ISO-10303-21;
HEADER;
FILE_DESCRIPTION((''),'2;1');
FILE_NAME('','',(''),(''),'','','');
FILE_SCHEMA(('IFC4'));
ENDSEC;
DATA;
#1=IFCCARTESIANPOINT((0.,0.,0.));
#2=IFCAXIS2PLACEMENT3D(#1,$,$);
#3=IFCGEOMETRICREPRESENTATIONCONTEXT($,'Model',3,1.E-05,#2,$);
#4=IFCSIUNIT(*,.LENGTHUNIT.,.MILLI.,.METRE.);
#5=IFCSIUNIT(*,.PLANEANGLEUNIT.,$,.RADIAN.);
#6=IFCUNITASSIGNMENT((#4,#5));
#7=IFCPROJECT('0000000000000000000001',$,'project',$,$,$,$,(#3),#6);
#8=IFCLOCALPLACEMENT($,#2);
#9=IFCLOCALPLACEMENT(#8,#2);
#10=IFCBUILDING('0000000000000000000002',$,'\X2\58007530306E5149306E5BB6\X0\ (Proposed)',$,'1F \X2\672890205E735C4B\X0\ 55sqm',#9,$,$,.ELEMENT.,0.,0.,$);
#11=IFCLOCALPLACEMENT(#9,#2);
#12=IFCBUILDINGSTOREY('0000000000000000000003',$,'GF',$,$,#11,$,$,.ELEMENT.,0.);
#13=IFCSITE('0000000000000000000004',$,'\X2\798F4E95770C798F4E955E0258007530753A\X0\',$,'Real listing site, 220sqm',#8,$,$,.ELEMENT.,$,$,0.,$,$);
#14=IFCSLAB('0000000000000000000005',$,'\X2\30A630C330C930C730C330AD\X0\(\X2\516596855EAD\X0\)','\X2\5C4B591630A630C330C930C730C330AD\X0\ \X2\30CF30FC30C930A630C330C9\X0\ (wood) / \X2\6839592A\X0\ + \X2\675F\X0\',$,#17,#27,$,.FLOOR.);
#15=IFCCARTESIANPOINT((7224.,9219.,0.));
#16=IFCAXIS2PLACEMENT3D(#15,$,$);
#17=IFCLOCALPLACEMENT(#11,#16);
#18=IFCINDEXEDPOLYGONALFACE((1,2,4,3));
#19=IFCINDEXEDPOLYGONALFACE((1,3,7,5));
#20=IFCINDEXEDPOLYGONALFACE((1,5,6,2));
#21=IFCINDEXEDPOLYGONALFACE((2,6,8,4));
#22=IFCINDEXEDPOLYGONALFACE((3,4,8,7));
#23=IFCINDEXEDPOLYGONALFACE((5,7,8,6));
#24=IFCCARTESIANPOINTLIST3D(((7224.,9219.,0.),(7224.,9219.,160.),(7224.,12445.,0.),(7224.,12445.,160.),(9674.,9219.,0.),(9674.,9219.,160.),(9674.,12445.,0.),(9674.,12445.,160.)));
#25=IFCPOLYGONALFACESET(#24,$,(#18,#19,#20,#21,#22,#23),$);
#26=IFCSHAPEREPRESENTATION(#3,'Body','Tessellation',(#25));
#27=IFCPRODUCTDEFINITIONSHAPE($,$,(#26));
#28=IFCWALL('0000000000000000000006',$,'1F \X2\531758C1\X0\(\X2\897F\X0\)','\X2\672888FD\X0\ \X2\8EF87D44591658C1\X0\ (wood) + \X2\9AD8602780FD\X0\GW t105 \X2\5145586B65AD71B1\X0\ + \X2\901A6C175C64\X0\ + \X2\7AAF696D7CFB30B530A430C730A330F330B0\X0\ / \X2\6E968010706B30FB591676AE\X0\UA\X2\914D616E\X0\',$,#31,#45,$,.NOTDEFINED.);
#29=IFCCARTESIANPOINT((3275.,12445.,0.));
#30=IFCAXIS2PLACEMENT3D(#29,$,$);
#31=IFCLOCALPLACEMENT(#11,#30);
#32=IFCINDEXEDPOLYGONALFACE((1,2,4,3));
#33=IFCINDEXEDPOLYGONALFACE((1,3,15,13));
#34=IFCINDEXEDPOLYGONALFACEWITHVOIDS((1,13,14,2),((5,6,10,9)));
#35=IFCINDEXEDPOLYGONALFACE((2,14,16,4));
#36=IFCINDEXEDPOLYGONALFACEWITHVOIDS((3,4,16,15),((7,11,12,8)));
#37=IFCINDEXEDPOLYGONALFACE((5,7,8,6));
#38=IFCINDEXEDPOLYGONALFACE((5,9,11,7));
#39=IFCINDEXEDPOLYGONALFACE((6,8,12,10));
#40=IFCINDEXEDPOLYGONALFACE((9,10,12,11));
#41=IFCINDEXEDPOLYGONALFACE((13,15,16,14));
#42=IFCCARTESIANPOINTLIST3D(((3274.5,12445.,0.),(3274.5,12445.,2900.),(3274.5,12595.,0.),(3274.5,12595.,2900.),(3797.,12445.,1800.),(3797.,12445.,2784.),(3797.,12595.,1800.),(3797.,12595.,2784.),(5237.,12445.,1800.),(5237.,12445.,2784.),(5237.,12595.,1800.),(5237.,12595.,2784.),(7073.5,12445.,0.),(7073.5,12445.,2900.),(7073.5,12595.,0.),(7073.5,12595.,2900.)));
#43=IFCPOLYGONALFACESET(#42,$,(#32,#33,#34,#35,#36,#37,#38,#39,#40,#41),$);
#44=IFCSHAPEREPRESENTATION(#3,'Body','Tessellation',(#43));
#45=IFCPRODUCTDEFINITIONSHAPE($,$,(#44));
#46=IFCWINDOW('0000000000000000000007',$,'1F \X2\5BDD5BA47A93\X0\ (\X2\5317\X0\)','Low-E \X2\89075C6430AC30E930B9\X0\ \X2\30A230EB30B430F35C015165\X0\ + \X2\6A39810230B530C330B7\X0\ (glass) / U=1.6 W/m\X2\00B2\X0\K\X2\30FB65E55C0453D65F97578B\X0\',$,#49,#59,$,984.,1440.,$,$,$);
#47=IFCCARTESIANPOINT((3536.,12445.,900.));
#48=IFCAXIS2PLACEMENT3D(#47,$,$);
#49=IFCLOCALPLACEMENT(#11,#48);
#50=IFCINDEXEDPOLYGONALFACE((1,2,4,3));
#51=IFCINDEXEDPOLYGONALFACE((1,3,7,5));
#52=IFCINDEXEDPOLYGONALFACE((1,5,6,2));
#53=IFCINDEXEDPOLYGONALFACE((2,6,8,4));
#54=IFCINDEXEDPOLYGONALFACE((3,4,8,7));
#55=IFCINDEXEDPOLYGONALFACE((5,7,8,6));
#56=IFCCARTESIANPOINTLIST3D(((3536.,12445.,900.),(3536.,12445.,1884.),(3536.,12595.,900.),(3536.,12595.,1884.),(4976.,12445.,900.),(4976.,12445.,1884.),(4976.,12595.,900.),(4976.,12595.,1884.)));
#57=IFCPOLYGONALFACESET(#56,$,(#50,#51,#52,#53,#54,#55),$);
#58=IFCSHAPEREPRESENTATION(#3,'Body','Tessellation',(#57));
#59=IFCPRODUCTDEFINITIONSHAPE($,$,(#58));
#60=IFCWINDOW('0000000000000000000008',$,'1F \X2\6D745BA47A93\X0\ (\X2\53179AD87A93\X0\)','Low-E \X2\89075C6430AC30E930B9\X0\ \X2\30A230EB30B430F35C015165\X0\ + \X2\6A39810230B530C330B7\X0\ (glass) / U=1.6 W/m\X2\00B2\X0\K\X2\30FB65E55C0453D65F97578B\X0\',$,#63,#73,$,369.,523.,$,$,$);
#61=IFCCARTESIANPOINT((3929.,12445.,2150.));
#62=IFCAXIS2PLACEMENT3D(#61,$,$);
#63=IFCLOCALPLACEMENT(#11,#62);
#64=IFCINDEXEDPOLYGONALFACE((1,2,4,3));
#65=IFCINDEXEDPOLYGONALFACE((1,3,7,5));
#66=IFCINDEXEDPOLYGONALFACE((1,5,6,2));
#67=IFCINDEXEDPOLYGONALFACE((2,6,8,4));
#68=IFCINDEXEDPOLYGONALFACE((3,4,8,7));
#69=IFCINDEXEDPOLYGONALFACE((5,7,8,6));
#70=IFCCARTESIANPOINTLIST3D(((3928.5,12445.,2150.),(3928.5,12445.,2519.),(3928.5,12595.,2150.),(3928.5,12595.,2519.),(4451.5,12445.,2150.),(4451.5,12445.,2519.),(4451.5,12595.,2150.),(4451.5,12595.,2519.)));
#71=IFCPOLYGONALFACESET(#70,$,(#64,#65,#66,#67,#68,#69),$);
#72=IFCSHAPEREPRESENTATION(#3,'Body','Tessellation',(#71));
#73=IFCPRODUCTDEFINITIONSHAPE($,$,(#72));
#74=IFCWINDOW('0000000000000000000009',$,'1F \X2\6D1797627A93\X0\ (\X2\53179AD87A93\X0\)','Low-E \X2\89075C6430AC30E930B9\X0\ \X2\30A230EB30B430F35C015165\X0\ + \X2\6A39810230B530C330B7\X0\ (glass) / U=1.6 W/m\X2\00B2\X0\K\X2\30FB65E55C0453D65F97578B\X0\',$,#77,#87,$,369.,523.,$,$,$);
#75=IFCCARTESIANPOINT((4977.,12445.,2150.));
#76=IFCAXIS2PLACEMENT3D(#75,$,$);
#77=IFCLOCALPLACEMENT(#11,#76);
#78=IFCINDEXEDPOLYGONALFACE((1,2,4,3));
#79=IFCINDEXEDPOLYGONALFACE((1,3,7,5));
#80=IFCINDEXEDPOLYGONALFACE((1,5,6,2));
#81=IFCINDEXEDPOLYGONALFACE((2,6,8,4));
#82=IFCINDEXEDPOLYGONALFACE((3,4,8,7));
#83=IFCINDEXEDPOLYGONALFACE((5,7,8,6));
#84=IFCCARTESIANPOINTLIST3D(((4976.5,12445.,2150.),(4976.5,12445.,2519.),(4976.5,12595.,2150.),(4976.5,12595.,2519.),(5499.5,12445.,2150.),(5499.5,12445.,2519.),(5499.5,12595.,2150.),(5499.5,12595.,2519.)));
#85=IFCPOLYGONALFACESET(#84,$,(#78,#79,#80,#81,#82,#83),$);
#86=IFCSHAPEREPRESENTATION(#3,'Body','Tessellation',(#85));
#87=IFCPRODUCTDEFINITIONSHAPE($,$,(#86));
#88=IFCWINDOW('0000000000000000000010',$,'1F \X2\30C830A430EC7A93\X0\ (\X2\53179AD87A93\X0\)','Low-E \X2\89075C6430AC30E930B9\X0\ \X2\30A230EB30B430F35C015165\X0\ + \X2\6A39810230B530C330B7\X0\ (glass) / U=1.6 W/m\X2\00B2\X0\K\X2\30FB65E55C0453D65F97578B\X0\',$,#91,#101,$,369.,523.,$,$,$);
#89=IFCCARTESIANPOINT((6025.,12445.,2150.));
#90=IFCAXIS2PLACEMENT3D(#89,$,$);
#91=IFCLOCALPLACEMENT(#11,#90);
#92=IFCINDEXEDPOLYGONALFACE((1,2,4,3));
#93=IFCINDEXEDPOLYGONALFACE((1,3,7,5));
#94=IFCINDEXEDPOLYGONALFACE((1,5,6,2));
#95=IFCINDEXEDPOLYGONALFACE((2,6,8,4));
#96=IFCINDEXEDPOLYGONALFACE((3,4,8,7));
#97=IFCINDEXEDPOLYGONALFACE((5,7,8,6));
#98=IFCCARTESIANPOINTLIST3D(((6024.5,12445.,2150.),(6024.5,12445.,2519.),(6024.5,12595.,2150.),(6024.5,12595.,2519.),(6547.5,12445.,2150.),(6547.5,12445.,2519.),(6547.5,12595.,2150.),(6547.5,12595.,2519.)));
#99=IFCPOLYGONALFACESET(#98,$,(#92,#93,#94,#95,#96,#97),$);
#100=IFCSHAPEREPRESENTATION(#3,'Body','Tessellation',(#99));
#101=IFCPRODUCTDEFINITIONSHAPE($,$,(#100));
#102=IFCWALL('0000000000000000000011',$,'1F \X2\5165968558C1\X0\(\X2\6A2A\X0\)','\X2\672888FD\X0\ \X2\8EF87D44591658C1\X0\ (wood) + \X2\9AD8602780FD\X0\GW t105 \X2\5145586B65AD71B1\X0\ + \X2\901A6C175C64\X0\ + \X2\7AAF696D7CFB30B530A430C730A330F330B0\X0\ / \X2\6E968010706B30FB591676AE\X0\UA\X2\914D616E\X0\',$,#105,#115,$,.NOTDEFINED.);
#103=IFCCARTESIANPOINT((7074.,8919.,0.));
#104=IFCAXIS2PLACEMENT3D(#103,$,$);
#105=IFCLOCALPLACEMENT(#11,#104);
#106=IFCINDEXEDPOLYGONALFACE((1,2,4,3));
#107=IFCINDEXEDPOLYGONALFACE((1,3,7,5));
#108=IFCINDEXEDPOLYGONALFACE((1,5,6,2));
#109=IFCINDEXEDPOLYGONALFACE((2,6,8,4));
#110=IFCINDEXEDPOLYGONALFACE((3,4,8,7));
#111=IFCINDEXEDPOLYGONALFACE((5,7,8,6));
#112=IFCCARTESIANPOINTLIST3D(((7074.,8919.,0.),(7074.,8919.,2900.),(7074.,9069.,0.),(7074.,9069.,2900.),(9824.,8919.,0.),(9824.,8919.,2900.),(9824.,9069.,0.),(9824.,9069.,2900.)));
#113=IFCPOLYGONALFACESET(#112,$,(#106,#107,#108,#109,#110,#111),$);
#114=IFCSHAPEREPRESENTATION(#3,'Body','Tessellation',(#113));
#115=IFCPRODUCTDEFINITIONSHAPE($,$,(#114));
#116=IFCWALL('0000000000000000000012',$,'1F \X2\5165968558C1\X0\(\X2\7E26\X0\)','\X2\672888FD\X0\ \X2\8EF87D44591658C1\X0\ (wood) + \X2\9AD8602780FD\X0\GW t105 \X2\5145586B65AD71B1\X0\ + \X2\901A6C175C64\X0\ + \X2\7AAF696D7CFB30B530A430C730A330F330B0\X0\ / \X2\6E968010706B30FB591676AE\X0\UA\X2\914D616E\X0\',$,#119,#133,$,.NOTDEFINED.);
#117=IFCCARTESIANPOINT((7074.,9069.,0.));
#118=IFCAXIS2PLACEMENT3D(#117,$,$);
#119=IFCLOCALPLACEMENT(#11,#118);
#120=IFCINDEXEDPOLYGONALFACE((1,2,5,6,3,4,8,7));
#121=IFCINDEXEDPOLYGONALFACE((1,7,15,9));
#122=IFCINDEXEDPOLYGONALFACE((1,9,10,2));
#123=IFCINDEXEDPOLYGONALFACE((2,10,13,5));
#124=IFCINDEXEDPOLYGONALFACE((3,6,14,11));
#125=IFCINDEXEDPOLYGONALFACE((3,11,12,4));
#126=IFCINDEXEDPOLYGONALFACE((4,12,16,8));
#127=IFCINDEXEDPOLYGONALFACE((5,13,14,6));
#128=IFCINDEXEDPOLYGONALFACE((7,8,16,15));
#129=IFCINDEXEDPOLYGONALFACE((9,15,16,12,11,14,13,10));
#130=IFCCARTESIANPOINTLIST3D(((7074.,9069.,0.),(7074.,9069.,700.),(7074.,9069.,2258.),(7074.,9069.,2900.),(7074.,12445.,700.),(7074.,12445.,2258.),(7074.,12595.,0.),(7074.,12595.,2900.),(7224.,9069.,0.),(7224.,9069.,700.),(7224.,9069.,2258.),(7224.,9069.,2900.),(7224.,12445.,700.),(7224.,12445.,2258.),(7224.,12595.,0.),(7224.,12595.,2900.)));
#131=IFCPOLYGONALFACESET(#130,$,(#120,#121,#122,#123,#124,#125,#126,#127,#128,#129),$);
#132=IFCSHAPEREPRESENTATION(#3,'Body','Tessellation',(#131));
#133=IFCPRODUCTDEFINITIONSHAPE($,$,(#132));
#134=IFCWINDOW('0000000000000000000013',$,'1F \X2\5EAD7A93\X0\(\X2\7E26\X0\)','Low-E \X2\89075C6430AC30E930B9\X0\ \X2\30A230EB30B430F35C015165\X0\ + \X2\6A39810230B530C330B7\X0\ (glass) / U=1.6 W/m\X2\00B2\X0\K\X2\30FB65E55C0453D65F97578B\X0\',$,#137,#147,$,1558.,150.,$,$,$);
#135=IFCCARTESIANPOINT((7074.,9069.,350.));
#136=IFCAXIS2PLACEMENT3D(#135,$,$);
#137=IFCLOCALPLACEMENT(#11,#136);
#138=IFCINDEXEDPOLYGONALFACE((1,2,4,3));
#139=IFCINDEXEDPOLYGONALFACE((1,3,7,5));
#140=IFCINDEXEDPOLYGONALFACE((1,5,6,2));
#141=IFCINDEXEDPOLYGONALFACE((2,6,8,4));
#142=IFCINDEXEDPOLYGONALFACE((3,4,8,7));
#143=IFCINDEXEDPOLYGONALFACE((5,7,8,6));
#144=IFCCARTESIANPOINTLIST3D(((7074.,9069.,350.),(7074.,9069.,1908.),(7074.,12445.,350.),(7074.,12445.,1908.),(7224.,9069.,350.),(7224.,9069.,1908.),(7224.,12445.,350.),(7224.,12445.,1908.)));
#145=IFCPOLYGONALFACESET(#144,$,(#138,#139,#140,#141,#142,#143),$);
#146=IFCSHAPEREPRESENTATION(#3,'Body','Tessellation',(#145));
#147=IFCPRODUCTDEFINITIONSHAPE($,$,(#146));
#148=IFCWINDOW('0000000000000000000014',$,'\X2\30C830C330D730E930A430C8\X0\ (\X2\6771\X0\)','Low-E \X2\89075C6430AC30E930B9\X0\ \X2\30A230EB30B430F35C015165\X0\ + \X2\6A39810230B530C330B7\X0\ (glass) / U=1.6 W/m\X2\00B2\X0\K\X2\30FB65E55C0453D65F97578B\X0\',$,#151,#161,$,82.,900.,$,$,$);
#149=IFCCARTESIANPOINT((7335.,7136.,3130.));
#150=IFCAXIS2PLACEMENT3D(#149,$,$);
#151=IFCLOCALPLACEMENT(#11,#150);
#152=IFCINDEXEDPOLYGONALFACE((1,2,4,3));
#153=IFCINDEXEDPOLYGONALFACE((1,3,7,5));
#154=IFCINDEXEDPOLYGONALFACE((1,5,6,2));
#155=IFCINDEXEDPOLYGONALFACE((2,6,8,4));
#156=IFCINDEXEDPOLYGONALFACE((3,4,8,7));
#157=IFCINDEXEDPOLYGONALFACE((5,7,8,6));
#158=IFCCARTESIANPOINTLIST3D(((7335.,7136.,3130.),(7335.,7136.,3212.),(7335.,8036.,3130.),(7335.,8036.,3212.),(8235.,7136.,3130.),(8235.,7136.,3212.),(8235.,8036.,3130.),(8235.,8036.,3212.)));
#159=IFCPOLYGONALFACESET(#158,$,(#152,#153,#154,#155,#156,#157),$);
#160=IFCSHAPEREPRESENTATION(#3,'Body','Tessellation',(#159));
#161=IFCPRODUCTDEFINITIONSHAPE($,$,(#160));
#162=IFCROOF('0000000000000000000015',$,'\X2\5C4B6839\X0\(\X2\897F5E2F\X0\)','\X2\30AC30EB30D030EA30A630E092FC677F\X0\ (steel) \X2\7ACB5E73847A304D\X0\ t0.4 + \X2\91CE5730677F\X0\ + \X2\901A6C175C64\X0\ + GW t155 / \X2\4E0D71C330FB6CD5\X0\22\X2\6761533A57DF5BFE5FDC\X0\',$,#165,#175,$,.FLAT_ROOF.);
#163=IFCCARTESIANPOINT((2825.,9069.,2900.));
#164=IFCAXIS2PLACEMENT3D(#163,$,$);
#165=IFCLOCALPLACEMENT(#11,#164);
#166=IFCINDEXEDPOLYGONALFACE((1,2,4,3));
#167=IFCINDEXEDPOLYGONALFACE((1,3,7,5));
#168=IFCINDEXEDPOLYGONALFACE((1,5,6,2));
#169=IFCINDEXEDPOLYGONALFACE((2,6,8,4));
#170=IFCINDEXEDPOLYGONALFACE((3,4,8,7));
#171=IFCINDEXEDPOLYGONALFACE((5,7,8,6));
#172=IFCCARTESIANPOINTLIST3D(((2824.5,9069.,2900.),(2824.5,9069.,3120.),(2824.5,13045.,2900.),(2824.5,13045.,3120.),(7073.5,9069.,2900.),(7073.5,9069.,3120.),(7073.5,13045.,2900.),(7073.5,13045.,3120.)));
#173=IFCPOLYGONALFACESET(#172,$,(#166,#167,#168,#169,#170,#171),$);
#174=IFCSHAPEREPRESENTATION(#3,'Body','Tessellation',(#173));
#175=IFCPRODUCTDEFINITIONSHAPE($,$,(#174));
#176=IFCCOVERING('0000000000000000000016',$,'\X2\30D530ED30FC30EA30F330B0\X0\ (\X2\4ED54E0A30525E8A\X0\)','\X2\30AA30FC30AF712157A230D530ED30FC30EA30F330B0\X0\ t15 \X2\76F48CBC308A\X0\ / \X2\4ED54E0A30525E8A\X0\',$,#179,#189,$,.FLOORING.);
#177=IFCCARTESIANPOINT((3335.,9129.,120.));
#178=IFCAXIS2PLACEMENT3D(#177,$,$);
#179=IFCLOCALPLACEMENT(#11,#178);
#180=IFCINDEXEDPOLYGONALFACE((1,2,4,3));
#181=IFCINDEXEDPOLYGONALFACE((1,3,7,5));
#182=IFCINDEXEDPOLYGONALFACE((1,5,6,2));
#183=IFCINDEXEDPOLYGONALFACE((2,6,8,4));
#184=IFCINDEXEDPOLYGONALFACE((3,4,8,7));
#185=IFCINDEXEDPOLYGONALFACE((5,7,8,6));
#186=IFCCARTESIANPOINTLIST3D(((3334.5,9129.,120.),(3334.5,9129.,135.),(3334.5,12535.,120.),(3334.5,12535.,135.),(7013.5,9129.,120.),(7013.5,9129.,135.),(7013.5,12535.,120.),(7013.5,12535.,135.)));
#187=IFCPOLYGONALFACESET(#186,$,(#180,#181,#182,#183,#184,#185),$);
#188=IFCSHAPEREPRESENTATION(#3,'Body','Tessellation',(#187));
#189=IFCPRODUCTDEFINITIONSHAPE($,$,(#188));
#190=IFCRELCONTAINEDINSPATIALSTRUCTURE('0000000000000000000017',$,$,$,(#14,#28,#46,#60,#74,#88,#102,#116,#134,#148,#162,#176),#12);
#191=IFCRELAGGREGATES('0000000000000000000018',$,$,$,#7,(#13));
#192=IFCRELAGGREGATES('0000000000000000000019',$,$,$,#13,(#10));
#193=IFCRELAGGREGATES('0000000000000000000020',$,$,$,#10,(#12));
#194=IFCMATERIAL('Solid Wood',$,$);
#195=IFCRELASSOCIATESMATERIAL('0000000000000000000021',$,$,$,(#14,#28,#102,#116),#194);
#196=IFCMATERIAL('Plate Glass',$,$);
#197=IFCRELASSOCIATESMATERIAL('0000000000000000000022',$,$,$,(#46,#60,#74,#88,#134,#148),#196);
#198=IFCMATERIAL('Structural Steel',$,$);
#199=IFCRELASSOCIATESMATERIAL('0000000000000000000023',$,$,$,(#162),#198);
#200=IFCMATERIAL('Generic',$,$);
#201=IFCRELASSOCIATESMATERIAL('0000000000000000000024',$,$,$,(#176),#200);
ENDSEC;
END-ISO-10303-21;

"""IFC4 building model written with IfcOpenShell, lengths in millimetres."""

from ifc_helpers import new_model, si_unit, frame, frame_2d, origin, place, context, project, spatial, rectangle, extrude, material, element, fill, save


model = new_model("IFC4")

# Units and contexts
model_context = context("Model", 3, precision=1e-05, world=origin())
ifc_project = project(units=[si_unit("LENGTHUNIT", "METRE", prefix="MILLI"), si_unit("PLANEANGLEUNIT", "RADIAN")], contexts=[model_context])

# Site, building, storey
site_placement = place(None, origin())
site = spatial("IfcSite", under=ifc_project, at=site_placement, Name="福井県福井市堀田町", ObjectType="Real listing site, 220sqm", CompositionType="ELEMENT", RefElevation=0.0)
building_placement = place(site_placement, origin())
building = spatial("IfcBuilding", under=site, at=building_placement, Name="堀田の光の家 (Proposed)", ObjectType="1F 木造平屋 55sqm", CompositionType="ELEMENT", ElevationOfRefHeight=0.0, ElevationOfTerrain=0.0)
storey_placement = place(building_placement, origin())
storey = spatial("IfcBuildingStorey", under=building, at=storey_placement, Name="GF", CompositionType="ELEMENT", Elevation=0.0)

# Slab
ifc_material_1 = material(Name="Solid Wood")
slab_1_placement = place(storey_placement, frame((7224.0, 9219.0, 0.0)))
element("IfcSlab", 1, at=slab_1_placement, inside=storey, material=ifc_material_1, Name="ウッドデッキ(入隅庭)", Description="屋外ウッドデッキ ハードウッド (wood) / 根太 + 束", PredefinedType="FLOOR", context=model_context, shape_type="SweptSolid", body=[
    extrude(rectangle(XDim=2450.0, YDim=3226.0, at=frame_2d((1225.0, 1613.0))), frame((7224.0, 9219.0, 0.0)), (0.0, 0.0, 1.0), 160.0),
])

# Wall, openings, windows
wall_1_placement = place(storey_placement, frame((3275.0, 12445.0, 0.0)))
wall_1 = element("IfcWall", 2, at=wall_1_placement, inside=storey, material=ifc_material_1, Name="1F 北壁(西)", Description="木製 軸組外壁 (wood) + 高性能GW t105 充填断熱 + 通気層 + 窯業系サイディング / 準耐火・外皮UA配慮", PredefinedType="NOTDEFINED", context=model_context, shape_type="SweptSolid", body=[
    extrude(rectangle(XDim=3799.0, YDim=150.0, at=frame_2d((1899.0, 75.0))), frame((3275.0, 12445.0, 0.0)), (0.0, 0.0, 1.0), 2900.0),
])
opening_1_placement = place(storey_placement, frame((3536.0, 12445.0, 900.0)))
opening_1 = element("IfcOpeningElement", 3, at=opening_1_placement, cuts=wall_1, PredefinedType="NOTDEFINED", context=model_context, shape_type="SweptSolid", body=[
    extrude(rectangle(XDim=1440.0, YDim=150.0, at=frame_2d((720.0, 75.0))), frame((3536.0, 12445.0, 900.0)), (0.0, 0.0, 1.0), 984.0),
])
opening_2_placement = place(storey_placement, frame((3929.0, 12445.0, 2150.0)))
opening_2 = element("IfcOpeningElement", 4, at=opening_2_placement, cuts=wall_1, PredefinedType="NOTDEFINED", context=model_context, shape_type="SweptSolid", body=[
    extrude(rectangle(XDim=523.0, YDim=150.0, at=frame_2d((261.0, 75.0))), frame((3929.0, 12445.0, 2150.0)), (0.0, 0.0, 1.0), 369.0),
])
opening_3_placement = place(storey_placement, frame((4977.0, 12445.0, 2150.0)))
opening_3 = element("IfcOpeningElement", 5, at=opening_3_placement, cuts=wall_1, PredefinedType="NOTDEFINED", context=model_context, shape_type="SweptSolid", body=[
    extrude(rectangle(XDim=523.0, YDim=150.0, at=frame_2d((261.0, 75.0))), frame((4977.0, 12445.0, 2150.0)), (0.0, 0.0, 1.0), 369.0),
])
opening_4_placement = place(storey_placement, frame((6025.0, 12445.0, 2150.0)))
opening_4 = element("IfcOpeningElement", 6, at=opening_4_placement, cuts=wall_1, PredefinedType="NOTDEFINED", context=model_context, shape_type="SweptSolid", body=[
    extrude(rectangle(XDim=523.0, YDim=150.0, at=frame_2d((261.0, 75.0))), frame((6025.0, 12445.0, 2150.0)), (0.0, 0.0, 1.0), 369.0),
])
ifc_material_2 = material(Name="Plate Glass")
window_1_placement = place(storey_placement, frame((3536.0, 12445.0, 900.0)))
window_1 = element("IfcWindow", 7, at=window_1_placement, inside=storey, material=ifc_material_2, Name="1F 寝室窓 (北)", Description="Low-E 複層ガラス アルゴン封入 + 樹脂サッシ (glass) / U=1.6 W/m²K・日射取得型", OverallHeight=984.0, OverallWidth=1440.0, context=model_context, shape_type="SweptSolid", body=[
    extrude(rectangle(XDim=1440.0, YDim=150.0, at=frame_2d((720.0, 75.0))), frame((3536.0, 12445.0, 900.0)), (0.0, 0.0, 1.0), 984.0),
])
fill(opening_1, window_1)
window_2_placement = place(storey_placement, frame((3929.0, 12445.0, 2150.0)))
window_2 = element("IfcWindow", 8, at=window_2_placement, inside=storey, material=ifc_material_2, Name="1F 浴室窓 (北高窓)", Description="Low-E 複層ガラス アルゴン封入 + 樹脂サッシ (glass) / U=1.6 W/m²K・日射取得型", OverallHeight=369.0, OverallWidth=523.0, context=model_context, shape_type="SweptSolid", body=[
    extrude(rectangle(XDim=523.0, YDim=150.0, at=frame_2d((261.0, 75.0))), frame((3929.0, 12445.0, 2150.0)), (0.0, 0.0, 1.0), 369.0),
])
fill(opening_2, window_2)
window_3_placement = place(storey_placement, frame((4977.0, 12445.0, 2150.0)))
window_3 = element("IfcWindow", 9, at=window_3_placement, inside=storey, material=ifc_material_2, Name="1F 洗面窓 (北高窓)", Description="Low-E 複層ガラス アルゴン封入 + 樹脂サッシ (glass) / U=1.6 W/m²K・日射取得型", OverallHeight=369.0, OverallWidth=523.0, context=model_context, shape_type="SweptSolid", body=[
    extrude(rectangle(XDim=523.0, YDim=150.0, at=frame_2d((261.0, 75.0))), frame((4977.0, 12445.0, 2150.0)), (0.0, 0.0, 1.0), 369.0),
])
fill(opening_3, window_3)
window_4_placement = place(storey_placement, frame((6025.0, 12445.0, 2150.0)))
window_4 = element("IfcWindow", 10, at=window_4_placement, inside=storey, material=ifc_material_2, Name="1F トイレ窓 (北高窓)", Description="Low-E 複層ガラス アルゴン封入 + 樹脂サッシ (glass) / U=1.6 W/m²K・日射取得型", OverallHeight=369.0, OverallWidth=523.0, context=model_context, shape_type="SweptSolid", body=[
    extrude(rectangle(XDim=523.0, YDim=150.0, at=frame_2d((261.0, 75.0))), frame((6025.0, 12445.0, 2150.0)), (0.0, 0.0, 1.0), 369.0),
])
fill(opening_4, window_4)

# Wall
wall_2_placement = place(storey_placement, frame((7074.0, 8919.0, 0.0)))
element("IfcWall", 11, at=wall_2_placement, inside=storey, material=ifc_material_1, Name="1F 入隅壁(横)", Description="木製 軸組外壁 (wood) + 高性能GW t105 充填断熱 + 通気層 + 窯業系サイディング / 準耐火・外皮UA配慮", PredefinedType="NOTDEFINED", context=model_context, shape_type="SweptSolid", body=[
    extrude(rectangle(XDim=2750.0, YDim=150.0, at=frame_2d((1375.0, 75.0))), frame((7074.0, 8919.0, 0.0)), (0.0, 0.0, 1.0), 2900.0),
])

# Wall, opening, window
wall_3_placement = place(storey_placement, frame((7074.0, 9069.0, 0.0)))
wall_3 = element("IfcWall", 12, at=wall_3_placement, inside=storey, material=ifc_material_1, Name="1F 入隅壁(縦)", Description="木製 軸組外壁 (wood) + 高性能GW t105 充填断熱 + 通気層 + 窯業系サイディング / 準耐火・外皮UA配慮", PredefinedType="NOTDEFINED", context=model_context, shape_type="SweptSolid", body=[
    extrude(rectangle(XDim=150.0, YDim=3526.0, at=frame_2d((75.0, 1763.0))), frame((7074.0, 9069.0, 0.0)), (0.0, 0.0, 1.0), 2900.0),
])
opening_5_placement = place(storey_placement, frame((7074.0, 9069.0, 350.0)))
opening_5 = element("IfcOpeningElement", 13, at=opening_5_placement, cuts=wall_3, PredefinedType="NOTDEFINED", context=model_context, shape_type="SweptSolid", body=[
    extrude(rectangle(XDim=150.0, YDim=3376.0, at=frame_2d((75.0, 1688.0))), frame((7074.0, 9069.0, 350.0)), (0.0, 0.0, 1.0), 1558.0),
])
window_5_placement = place(storey_placement, frame((7074.0, 9069.0, 350.0)))
window_5 = element("IfcWindow", 14, at=window_5_placement, inside=storey, material=ifc_material_2, Name="1F 庭窓(縦)", Description="Low-E 複層ガラス アルゴン封入 + 樹脂サッシ (glass) / U=1.6 W/m²K・日射取得型", OverallHeight=1558.0, OverallWidth=150.0, context=model_context, shape_type="SweptSolid", body=[
    extrude(rectangle(XDim=150.0, YDim=3376.0, at=frame_2d((75.0, 1688.0))), frame((7074.0, 9069.0, 350.0)), (0.0, 0.0, 1.0), 1558.0),
])
fill(opening_5, window_5)

# Window
window_6_placement = place(storey_placement, frame((7335.0, 7136.0, 3130.0)))
element("IfcWindow", 15, at=window_6_placement, inside=storey, material=ifc_material_2, Name="トップライト (東)", Description="Low-E 複層ガラス アルゴン封入 + 樹脂サッシ (glass) / U=1.6 W/m²K・日射取得型", OverallHeight=82.0, OverallWidth=900.0, context=model_context, shape_type="SweptSolid", body=[
    extrude(rectangle(XDim=900.0, YDim=900.0, at=frame_2d((450.0, 450.0))), frame((7335.0, 7136.0, 3130.0)), (0.0, 0.0, 1.0), 82.0),
])

# Roof
ifc_material_3 = material(Name="Structural Steel")
roof_placement = place(storey_placement, frame((2825.0, 9069.0, 2900.0)))
element("IfcRoof", 16, at=roof_placement, inside=storey, material=ifc_material_3, Name="屋根(西帯)", Description="ガルバリウム鋼板 (steel) 立平葺き t0.4 + 野地板 + 通気層 + GW t155 / 不燃・法22条区域対応", PredefinedType="FLAT_ROOF", context=model_context, shape_type="SweptSolid", body=[
    extrude(rectangle(XDim=4249.0, YDim=3976.0, at=frame_2d((2124.0, 1988.0))), frame((2825.0, 9069.0, 2900.0)), (0.0, 0.0, 1.0), 220.0),
])

# Covering
ifc_material_4 = material(Name="Generic")
covering_placement = place(storey_placement, frame((3335.0, 9129.0, 120.0)))
element("IfcCovering", 17, at=covering_placement, inside=storey, material=ifc_material_4, Name="フローリング (仕上げ床)", Description="オーク無垢フローリング t15 直貼り / 仕上げ床", PredefinedType="FLOORING", context=model_context, shape_type="SweptSolid", body=[
    extrude(rectangle(XDim=3679.0, YDim=3406.0, at=frame_2d((1839.0, 1703.0))), frame((3335.0, 9129.0, 120.0)), (0.0, 0.0, 1.0), 15.0),
])

save(model, "model.ifc")
